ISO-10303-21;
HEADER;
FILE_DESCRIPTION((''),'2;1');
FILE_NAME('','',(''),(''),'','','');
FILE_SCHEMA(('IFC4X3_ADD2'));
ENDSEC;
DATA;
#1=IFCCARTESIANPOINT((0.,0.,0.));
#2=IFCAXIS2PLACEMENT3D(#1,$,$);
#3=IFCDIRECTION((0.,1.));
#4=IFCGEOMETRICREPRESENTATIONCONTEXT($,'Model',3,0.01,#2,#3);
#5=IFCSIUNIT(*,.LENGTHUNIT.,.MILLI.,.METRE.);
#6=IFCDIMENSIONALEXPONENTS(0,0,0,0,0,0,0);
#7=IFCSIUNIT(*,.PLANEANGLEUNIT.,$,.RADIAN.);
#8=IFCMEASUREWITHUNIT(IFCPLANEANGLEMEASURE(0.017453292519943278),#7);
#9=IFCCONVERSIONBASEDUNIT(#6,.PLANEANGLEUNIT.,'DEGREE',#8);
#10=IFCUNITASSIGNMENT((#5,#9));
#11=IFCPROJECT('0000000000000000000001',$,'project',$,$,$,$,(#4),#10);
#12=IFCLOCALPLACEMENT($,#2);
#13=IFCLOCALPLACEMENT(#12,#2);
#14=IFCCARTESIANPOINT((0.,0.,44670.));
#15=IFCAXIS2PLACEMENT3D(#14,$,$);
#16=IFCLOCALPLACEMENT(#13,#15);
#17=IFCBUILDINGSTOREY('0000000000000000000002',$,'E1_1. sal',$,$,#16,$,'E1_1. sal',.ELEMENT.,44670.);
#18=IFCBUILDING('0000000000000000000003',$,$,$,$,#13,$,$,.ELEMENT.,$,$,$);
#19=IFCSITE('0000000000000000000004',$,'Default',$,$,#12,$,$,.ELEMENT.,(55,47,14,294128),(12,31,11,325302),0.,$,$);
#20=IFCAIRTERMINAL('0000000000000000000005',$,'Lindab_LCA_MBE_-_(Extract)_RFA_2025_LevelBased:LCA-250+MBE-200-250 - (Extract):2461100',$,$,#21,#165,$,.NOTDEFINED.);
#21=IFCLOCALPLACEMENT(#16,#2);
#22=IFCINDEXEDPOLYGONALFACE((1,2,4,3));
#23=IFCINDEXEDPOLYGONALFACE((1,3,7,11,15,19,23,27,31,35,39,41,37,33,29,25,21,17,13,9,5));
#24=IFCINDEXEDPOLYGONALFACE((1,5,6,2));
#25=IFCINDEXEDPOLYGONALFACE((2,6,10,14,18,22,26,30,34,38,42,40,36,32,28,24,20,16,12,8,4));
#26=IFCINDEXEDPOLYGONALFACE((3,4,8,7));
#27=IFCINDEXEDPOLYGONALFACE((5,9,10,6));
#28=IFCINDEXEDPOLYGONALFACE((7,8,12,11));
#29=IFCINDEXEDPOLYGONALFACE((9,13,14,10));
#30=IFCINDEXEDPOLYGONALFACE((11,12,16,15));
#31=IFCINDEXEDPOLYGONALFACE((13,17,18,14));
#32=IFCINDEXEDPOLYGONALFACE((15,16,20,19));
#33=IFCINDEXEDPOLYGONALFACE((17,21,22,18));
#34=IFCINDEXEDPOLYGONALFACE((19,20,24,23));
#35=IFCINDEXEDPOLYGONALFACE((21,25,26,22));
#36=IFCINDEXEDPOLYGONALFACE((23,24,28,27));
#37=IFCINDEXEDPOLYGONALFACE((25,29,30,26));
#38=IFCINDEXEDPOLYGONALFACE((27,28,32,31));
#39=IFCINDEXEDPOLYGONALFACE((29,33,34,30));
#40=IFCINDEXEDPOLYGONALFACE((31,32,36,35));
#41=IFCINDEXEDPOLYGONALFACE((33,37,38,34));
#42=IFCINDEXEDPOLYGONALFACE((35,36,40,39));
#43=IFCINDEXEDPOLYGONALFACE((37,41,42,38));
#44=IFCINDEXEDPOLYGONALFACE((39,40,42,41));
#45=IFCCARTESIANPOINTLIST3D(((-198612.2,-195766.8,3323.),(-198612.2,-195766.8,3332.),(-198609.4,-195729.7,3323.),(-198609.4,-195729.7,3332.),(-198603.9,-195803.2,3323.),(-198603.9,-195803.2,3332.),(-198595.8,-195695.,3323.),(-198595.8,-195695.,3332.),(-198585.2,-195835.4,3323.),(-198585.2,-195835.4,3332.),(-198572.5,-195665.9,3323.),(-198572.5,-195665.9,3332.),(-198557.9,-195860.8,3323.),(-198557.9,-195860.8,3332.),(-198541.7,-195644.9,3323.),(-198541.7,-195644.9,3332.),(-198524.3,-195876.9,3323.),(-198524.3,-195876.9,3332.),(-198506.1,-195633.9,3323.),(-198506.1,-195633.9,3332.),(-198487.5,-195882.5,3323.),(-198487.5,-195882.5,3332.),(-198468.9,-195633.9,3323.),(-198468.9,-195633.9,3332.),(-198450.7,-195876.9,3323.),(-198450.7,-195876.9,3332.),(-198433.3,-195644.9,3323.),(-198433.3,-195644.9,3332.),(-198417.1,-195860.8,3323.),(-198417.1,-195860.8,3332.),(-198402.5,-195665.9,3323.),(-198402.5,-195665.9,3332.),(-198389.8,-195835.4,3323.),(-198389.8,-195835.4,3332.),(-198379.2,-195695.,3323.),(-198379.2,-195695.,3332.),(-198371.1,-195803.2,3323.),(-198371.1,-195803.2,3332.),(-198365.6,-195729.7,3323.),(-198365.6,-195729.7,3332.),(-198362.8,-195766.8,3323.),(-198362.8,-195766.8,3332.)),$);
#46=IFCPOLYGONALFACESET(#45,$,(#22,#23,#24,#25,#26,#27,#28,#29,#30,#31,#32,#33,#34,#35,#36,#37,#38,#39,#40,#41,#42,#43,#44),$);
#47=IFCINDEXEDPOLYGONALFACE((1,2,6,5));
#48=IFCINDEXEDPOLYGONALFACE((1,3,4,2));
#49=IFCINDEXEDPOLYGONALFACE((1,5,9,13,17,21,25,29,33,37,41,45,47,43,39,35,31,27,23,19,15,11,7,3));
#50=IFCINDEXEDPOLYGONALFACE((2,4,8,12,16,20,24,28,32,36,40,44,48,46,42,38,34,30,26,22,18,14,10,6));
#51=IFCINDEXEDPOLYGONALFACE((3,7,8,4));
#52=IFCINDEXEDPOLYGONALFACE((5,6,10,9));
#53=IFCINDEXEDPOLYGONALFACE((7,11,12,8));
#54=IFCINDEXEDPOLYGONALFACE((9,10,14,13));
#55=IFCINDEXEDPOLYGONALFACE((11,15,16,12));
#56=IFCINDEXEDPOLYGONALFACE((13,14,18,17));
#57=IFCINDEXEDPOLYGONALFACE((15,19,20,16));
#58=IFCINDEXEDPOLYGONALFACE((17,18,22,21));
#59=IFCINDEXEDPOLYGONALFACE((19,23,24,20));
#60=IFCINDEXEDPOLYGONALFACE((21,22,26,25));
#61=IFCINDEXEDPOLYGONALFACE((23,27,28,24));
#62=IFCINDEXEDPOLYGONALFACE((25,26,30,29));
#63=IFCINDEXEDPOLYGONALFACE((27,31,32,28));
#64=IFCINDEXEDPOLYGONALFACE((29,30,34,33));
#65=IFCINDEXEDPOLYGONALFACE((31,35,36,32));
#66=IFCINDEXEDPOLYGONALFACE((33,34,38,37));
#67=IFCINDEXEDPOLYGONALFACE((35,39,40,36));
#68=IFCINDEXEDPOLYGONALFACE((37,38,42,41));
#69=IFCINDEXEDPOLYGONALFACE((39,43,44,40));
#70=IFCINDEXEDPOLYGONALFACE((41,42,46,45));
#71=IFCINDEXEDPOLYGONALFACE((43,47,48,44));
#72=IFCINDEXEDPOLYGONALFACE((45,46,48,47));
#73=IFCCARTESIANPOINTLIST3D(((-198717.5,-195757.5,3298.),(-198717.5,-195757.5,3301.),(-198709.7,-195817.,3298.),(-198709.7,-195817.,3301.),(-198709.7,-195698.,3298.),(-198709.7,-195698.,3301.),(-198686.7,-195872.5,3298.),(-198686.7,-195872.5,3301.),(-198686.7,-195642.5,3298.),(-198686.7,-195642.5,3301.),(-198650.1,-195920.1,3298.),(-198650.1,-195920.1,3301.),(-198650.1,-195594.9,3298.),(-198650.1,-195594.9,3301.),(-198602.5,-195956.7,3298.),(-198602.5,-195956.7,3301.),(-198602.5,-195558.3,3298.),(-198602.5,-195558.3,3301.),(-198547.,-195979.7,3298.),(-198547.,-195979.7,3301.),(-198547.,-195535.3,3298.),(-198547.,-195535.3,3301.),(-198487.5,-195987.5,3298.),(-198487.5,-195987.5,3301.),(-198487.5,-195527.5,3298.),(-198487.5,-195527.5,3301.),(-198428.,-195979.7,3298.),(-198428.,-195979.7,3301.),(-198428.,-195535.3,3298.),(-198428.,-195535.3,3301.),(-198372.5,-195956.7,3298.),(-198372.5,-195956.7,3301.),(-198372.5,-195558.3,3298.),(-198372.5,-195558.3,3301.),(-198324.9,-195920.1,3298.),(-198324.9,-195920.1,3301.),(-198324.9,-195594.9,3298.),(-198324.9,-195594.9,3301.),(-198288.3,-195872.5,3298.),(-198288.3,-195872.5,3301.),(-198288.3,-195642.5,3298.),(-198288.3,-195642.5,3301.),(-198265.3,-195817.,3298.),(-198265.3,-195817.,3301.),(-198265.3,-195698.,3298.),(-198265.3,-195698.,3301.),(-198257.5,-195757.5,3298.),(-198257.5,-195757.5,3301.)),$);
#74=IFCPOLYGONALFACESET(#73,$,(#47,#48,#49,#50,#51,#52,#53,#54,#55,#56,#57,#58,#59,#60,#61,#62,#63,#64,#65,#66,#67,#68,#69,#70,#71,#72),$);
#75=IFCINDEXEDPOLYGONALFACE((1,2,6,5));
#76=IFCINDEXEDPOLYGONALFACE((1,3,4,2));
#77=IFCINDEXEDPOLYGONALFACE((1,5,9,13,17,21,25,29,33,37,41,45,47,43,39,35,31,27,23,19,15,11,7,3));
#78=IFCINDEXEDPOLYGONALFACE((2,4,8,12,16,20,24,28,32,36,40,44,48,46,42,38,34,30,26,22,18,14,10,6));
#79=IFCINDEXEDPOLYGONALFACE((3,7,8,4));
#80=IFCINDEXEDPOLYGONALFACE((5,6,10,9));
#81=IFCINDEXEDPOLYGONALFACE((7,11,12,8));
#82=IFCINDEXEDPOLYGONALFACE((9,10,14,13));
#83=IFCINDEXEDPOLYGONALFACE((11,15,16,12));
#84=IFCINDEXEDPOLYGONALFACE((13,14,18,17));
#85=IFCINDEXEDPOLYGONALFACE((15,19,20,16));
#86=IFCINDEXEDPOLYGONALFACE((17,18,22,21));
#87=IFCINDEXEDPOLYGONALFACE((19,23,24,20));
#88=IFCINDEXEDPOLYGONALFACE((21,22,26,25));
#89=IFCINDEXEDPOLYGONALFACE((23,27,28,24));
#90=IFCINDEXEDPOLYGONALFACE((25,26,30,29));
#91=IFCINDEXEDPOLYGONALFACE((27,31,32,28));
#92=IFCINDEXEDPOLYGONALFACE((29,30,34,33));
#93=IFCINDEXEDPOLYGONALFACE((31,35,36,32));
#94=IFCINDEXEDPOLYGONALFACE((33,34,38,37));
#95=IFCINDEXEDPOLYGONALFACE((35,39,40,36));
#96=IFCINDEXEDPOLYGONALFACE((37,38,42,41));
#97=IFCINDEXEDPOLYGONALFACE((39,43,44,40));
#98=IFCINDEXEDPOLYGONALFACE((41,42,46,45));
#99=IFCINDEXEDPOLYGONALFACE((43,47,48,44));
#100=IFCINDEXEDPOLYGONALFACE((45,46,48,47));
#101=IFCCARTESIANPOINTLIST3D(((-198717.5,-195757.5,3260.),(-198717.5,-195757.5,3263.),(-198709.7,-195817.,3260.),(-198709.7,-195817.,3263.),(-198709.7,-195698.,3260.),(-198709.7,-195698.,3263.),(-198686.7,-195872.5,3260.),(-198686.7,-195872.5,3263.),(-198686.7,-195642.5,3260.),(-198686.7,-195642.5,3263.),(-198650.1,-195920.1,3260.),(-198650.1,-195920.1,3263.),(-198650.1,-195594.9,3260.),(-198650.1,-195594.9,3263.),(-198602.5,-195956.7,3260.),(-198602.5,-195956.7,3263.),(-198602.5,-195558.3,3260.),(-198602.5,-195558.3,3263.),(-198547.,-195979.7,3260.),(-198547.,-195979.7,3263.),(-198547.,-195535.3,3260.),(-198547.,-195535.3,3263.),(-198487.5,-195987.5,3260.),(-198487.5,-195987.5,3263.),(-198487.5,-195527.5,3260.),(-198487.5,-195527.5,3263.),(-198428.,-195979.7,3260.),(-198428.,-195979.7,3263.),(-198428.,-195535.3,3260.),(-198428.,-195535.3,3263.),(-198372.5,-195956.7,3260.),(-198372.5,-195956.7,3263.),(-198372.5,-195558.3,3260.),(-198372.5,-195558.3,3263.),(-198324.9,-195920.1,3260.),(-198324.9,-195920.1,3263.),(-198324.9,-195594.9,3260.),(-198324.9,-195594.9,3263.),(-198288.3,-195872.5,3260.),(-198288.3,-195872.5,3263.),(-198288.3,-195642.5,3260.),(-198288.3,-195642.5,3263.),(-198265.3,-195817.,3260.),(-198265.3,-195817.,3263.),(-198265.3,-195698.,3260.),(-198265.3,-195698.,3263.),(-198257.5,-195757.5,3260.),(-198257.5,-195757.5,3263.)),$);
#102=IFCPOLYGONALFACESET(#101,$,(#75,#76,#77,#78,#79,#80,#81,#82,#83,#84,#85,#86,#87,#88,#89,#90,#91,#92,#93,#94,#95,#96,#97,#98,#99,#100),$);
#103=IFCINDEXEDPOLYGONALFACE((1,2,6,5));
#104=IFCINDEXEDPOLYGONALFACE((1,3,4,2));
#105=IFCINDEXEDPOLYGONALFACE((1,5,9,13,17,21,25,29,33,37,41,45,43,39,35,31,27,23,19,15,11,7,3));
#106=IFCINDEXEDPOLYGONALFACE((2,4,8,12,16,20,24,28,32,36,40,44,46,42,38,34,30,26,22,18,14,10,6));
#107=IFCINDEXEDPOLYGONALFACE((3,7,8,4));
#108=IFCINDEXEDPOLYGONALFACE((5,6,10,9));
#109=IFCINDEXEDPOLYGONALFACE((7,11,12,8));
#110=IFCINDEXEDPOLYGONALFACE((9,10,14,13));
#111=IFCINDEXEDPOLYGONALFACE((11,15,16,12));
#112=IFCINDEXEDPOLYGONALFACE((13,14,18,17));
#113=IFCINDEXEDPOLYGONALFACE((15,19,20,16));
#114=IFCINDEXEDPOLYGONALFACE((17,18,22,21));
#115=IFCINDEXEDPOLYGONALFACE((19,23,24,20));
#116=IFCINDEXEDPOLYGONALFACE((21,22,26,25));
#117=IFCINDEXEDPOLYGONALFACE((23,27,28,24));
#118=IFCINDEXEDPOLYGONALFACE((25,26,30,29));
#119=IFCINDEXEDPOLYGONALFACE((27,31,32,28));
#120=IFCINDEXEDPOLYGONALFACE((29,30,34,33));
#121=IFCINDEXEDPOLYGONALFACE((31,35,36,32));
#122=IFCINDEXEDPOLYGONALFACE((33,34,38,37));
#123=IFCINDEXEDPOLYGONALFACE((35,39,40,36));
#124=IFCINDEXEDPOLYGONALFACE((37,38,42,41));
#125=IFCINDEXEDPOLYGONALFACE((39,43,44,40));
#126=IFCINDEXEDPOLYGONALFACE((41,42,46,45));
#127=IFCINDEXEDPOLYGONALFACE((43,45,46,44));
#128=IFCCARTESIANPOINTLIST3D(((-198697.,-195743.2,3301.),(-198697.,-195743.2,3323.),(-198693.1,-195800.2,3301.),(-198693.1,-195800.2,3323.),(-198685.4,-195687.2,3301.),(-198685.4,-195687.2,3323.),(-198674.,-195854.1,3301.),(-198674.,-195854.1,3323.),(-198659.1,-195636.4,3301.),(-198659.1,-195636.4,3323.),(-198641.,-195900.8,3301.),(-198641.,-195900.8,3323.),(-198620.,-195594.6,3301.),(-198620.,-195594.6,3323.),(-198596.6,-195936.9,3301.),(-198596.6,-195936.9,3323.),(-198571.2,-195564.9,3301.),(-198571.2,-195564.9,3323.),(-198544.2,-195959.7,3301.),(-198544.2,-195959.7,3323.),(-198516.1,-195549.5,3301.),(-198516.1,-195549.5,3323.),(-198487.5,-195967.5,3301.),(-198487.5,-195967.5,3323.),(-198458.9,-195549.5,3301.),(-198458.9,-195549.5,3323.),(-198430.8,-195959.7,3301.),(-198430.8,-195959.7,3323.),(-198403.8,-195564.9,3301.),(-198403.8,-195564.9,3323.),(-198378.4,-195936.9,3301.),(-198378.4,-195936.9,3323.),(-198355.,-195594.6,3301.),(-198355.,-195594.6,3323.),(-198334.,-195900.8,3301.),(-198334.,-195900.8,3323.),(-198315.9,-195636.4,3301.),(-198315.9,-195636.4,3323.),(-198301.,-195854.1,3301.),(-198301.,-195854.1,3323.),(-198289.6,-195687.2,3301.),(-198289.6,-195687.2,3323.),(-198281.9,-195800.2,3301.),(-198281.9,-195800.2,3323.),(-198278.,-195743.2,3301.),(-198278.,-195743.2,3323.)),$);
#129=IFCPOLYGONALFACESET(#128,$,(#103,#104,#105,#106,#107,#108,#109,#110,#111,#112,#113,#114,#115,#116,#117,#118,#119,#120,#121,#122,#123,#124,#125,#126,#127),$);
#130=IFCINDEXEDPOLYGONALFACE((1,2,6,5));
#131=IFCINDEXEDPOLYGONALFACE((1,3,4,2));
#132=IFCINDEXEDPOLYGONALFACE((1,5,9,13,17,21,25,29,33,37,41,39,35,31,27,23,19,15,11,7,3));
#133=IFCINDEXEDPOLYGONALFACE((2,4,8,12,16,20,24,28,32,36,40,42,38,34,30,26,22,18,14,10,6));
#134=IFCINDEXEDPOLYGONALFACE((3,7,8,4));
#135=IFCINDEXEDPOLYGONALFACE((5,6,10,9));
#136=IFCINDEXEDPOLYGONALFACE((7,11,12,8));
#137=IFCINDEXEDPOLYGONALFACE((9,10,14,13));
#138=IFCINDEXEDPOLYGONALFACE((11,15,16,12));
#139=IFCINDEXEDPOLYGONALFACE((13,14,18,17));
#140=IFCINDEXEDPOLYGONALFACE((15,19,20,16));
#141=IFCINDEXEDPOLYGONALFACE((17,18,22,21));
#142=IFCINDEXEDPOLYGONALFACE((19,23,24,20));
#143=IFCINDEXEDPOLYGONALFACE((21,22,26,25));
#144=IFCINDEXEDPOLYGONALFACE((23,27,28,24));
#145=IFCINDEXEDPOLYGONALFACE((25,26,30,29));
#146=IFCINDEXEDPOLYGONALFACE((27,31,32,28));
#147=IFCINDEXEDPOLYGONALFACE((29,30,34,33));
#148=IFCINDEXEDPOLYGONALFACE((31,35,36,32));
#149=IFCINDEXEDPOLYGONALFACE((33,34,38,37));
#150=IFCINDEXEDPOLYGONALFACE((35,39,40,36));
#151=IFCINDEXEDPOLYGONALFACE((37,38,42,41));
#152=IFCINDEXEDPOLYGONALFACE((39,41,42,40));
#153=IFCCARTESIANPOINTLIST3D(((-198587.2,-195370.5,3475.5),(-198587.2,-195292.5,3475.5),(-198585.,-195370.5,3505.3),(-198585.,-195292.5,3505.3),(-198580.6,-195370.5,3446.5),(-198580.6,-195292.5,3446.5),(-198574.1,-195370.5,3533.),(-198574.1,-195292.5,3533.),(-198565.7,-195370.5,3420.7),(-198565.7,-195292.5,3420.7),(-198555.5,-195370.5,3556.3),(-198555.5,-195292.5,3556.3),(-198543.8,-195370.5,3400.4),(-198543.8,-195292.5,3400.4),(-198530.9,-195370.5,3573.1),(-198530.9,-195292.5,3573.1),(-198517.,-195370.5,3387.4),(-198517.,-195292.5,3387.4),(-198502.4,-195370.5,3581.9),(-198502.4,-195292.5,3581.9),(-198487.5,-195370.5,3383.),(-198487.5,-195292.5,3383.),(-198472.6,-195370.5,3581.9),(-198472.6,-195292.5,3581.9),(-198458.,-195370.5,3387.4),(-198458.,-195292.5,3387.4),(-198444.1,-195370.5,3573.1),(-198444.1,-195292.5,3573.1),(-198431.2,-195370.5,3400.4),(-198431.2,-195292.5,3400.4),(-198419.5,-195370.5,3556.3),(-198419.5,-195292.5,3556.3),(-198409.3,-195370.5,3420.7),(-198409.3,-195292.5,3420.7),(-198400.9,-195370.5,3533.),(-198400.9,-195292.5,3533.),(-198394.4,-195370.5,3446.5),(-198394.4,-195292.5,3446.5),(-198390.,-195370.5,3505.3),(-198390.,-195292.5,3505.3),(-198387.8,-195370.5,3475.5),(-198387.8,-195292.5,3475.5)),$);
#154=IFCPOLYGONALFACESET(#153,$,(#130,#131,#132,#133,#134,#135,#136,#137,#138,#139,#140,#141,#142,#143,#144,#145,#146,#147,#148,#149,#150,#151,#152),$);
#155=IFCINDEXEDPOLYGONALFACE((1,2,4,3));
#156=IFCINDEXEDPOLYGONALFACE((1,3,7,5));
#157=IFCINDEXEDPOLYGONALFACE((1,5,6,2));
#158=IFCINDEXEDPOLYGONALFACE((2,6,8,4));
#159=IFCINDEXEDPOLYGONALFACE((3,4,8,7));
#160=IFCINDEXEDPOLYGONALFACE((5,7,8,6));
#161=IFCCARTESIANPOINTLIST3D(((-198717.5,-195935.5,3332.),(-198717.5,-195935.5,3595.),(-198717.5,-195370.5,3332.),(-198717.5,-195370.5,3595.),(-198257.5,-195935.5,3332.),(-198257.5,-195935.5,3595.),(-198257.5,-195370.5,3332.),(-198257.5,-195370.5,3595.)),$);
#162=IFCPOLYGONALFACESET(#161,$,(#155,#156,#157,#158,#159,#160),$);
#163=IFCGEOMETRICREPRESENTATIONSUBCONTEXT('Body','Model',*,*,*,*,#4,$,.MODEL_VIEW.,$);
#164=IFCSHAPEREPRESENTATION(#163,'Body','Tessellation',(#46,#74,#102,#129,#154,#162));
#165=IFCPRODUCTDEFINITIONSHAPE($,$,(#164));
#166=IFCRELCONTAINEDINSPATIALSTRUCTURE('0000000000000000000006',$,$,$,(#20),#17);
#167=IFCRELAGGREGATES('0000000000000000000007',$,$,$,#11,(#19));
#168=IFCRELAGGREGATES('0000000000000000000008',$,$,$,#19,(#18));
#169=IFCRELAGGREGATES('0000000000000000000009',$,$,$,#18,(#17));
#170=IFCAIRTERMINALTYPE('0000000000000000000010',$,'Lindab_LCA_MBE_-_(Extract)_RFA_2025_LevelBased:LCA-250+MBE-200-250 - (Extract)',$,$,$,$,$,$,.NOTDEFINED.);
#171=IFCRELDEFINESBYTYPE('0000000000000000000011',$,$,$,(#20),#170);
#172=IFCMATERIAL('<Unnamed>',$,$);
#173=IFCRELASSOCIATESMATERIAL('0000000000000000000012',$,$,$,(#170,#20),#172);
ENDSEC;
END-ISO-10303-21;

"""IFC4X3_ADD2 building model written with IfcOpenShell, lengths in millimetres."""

from ifc_helpers import new_model, entity, si_unit, converted_unit, direction, frame, frame_2d, origin, origin_2d_with_axis, place, context, subcontext, project, spatial, rectangle, circle, extrude, source, transform, mapped, material, type_object, type_shapes, element, save


model = new_model("IFC4X3_ADD2")

# Units and contexts
model_context = context("Model", 3, precision=0.01, world=origin(), true_north=direction((0.0, 1.0)))
body_context = subcontext(model_context, "Body", "Model", "MODEL_VIEW")
ifc_project = project(units=[si_unit("LENGTHUNIT", "METRE", prefix="MILLI"), converted_unit("PLANEANGLEUNIT", "DEGREE", entity("IfcPlaneAngleMeasure", 0.017453292519943278), si_unit("PLANEANGLEUNIT", "RADIAN"), dimensions=[0, 0, 0, 0, 0, 0, 0])], contexts=[model_context])

# Site, building, storey
site_placement = place(None, origin())
site = spatial("IfcSite", under=ifc_project, at=site_placement, Name="Default", CompositionType="ELEMENT", RefLatitude=(55, 47, 14, 294128), RefLongitude=(12, 31, 11, 325302), RefElevation=0.0)
building_placement = place(site_placement, origin())
building = spatial("IfcBuilding", under=site, at=building_placement, CompositionType="ELEMENT")
storey_placement = place(building_placement, frame((0.0, 0.0, 44670.0)))
storey = spatial("IfcBuildingStorey", under=building, at=storey_placement, Name="E1_1. sal", LongName="E1_1. sal", CompositionType="ELEMENT", Elevation=44670.0)

# Air terminal
ifc_material_1 = material(Name="<Unnamed>")
air_terminal_type = type_object("IfcAirTerminalType", Name="Lindab_LCA_MBE_-_(Extract)_RFA_2025_LevelBased:LCA-250+MBE-200-250 - (Extract)", PredefinedType="NOTDEFINED", material=ifc_material_1)
shared_shape_1 = source(origin(), body_context, "Body", "SweptSolid", [
    extrude(circle(Radius=125.0, at=frame_2d((0.0, 0.0), x_axis=(1.0, 0.0))), frame((0.0, 0.0, 22.0)), (0.0, 0.0, 1.0), 9.0),
    extrude(circle(Radius=230.0, at=frame_2d((0.0, 0.0), x_axis=(1.0, 0.0))), frame((0.0, 0.0, -3.0)), (0.0, 0.0, 1.0), 3.0),
    extrude(circle(Radius=230.0, at=frame_2d((0.0, 0.0), x_axis=(1.0, 0.0))), frame((0.0, 0.0, -41.0)), (0.0, 0.0, 1.0), 3.0),
    extrude(circle(Radius=210.0, at=frame_2d((0.0, 0.0), x_axis=(1.0, 0.0))), origin(), (0.0, 0.0, 1.0), 22.0),
    extrude(circle(Radius=100.0, at=frame_2d((0.0, 0.0), x_axis=(1.0, 0.0))), frame((-465.0, 0.0, 182.0), z_axis=(1.0, 0.0, 0.0), x_axis=(0.0, 0.0, -1.0)), (0.0, 0.0, 1.0), 78.0),
    extrude(rectangle(XDim=460.0, YDim=565.0, at=origin_2d_with_axis()), frame((-104.5, 0.0, 31.0), z_axis=(0.0, 0.0, 1.0), x_axis=(0.0, -1.0, 0.0)), (0.0, 0.0, 1.0), 263.0),
])
type_shapes(air_terminal_type, [shared_shape_1])
for number, where, z_axis, x_axis, name in (
    (1, (-198487.5, -195757.5, 3301.0), (0.0, 0.0, 1.0), (0.0, -1.0, 0.0), "Lindab_LCA_MBE_-_(Extract)_RFA_2025_LevelBased:LCA-250+MBE-200-250 - (Extract):2461100"),
):
    element("IfcAirTerminal", number, at=place(storey_placement, frame(where, z_axis=z_axis, x_axis=x_axis)), inside=storey, type_object=air_terminal_type, material=ifc_material_1, Name=name, PredefinedType="NOTDEFINED", context=body_context, shape_type="MappedRepresentation", body=[
        mapped(shared_shape_1, transform((0.0, 0.0, 0.0), scale=1.0)),
    ])

save(model, "model.ifc")
